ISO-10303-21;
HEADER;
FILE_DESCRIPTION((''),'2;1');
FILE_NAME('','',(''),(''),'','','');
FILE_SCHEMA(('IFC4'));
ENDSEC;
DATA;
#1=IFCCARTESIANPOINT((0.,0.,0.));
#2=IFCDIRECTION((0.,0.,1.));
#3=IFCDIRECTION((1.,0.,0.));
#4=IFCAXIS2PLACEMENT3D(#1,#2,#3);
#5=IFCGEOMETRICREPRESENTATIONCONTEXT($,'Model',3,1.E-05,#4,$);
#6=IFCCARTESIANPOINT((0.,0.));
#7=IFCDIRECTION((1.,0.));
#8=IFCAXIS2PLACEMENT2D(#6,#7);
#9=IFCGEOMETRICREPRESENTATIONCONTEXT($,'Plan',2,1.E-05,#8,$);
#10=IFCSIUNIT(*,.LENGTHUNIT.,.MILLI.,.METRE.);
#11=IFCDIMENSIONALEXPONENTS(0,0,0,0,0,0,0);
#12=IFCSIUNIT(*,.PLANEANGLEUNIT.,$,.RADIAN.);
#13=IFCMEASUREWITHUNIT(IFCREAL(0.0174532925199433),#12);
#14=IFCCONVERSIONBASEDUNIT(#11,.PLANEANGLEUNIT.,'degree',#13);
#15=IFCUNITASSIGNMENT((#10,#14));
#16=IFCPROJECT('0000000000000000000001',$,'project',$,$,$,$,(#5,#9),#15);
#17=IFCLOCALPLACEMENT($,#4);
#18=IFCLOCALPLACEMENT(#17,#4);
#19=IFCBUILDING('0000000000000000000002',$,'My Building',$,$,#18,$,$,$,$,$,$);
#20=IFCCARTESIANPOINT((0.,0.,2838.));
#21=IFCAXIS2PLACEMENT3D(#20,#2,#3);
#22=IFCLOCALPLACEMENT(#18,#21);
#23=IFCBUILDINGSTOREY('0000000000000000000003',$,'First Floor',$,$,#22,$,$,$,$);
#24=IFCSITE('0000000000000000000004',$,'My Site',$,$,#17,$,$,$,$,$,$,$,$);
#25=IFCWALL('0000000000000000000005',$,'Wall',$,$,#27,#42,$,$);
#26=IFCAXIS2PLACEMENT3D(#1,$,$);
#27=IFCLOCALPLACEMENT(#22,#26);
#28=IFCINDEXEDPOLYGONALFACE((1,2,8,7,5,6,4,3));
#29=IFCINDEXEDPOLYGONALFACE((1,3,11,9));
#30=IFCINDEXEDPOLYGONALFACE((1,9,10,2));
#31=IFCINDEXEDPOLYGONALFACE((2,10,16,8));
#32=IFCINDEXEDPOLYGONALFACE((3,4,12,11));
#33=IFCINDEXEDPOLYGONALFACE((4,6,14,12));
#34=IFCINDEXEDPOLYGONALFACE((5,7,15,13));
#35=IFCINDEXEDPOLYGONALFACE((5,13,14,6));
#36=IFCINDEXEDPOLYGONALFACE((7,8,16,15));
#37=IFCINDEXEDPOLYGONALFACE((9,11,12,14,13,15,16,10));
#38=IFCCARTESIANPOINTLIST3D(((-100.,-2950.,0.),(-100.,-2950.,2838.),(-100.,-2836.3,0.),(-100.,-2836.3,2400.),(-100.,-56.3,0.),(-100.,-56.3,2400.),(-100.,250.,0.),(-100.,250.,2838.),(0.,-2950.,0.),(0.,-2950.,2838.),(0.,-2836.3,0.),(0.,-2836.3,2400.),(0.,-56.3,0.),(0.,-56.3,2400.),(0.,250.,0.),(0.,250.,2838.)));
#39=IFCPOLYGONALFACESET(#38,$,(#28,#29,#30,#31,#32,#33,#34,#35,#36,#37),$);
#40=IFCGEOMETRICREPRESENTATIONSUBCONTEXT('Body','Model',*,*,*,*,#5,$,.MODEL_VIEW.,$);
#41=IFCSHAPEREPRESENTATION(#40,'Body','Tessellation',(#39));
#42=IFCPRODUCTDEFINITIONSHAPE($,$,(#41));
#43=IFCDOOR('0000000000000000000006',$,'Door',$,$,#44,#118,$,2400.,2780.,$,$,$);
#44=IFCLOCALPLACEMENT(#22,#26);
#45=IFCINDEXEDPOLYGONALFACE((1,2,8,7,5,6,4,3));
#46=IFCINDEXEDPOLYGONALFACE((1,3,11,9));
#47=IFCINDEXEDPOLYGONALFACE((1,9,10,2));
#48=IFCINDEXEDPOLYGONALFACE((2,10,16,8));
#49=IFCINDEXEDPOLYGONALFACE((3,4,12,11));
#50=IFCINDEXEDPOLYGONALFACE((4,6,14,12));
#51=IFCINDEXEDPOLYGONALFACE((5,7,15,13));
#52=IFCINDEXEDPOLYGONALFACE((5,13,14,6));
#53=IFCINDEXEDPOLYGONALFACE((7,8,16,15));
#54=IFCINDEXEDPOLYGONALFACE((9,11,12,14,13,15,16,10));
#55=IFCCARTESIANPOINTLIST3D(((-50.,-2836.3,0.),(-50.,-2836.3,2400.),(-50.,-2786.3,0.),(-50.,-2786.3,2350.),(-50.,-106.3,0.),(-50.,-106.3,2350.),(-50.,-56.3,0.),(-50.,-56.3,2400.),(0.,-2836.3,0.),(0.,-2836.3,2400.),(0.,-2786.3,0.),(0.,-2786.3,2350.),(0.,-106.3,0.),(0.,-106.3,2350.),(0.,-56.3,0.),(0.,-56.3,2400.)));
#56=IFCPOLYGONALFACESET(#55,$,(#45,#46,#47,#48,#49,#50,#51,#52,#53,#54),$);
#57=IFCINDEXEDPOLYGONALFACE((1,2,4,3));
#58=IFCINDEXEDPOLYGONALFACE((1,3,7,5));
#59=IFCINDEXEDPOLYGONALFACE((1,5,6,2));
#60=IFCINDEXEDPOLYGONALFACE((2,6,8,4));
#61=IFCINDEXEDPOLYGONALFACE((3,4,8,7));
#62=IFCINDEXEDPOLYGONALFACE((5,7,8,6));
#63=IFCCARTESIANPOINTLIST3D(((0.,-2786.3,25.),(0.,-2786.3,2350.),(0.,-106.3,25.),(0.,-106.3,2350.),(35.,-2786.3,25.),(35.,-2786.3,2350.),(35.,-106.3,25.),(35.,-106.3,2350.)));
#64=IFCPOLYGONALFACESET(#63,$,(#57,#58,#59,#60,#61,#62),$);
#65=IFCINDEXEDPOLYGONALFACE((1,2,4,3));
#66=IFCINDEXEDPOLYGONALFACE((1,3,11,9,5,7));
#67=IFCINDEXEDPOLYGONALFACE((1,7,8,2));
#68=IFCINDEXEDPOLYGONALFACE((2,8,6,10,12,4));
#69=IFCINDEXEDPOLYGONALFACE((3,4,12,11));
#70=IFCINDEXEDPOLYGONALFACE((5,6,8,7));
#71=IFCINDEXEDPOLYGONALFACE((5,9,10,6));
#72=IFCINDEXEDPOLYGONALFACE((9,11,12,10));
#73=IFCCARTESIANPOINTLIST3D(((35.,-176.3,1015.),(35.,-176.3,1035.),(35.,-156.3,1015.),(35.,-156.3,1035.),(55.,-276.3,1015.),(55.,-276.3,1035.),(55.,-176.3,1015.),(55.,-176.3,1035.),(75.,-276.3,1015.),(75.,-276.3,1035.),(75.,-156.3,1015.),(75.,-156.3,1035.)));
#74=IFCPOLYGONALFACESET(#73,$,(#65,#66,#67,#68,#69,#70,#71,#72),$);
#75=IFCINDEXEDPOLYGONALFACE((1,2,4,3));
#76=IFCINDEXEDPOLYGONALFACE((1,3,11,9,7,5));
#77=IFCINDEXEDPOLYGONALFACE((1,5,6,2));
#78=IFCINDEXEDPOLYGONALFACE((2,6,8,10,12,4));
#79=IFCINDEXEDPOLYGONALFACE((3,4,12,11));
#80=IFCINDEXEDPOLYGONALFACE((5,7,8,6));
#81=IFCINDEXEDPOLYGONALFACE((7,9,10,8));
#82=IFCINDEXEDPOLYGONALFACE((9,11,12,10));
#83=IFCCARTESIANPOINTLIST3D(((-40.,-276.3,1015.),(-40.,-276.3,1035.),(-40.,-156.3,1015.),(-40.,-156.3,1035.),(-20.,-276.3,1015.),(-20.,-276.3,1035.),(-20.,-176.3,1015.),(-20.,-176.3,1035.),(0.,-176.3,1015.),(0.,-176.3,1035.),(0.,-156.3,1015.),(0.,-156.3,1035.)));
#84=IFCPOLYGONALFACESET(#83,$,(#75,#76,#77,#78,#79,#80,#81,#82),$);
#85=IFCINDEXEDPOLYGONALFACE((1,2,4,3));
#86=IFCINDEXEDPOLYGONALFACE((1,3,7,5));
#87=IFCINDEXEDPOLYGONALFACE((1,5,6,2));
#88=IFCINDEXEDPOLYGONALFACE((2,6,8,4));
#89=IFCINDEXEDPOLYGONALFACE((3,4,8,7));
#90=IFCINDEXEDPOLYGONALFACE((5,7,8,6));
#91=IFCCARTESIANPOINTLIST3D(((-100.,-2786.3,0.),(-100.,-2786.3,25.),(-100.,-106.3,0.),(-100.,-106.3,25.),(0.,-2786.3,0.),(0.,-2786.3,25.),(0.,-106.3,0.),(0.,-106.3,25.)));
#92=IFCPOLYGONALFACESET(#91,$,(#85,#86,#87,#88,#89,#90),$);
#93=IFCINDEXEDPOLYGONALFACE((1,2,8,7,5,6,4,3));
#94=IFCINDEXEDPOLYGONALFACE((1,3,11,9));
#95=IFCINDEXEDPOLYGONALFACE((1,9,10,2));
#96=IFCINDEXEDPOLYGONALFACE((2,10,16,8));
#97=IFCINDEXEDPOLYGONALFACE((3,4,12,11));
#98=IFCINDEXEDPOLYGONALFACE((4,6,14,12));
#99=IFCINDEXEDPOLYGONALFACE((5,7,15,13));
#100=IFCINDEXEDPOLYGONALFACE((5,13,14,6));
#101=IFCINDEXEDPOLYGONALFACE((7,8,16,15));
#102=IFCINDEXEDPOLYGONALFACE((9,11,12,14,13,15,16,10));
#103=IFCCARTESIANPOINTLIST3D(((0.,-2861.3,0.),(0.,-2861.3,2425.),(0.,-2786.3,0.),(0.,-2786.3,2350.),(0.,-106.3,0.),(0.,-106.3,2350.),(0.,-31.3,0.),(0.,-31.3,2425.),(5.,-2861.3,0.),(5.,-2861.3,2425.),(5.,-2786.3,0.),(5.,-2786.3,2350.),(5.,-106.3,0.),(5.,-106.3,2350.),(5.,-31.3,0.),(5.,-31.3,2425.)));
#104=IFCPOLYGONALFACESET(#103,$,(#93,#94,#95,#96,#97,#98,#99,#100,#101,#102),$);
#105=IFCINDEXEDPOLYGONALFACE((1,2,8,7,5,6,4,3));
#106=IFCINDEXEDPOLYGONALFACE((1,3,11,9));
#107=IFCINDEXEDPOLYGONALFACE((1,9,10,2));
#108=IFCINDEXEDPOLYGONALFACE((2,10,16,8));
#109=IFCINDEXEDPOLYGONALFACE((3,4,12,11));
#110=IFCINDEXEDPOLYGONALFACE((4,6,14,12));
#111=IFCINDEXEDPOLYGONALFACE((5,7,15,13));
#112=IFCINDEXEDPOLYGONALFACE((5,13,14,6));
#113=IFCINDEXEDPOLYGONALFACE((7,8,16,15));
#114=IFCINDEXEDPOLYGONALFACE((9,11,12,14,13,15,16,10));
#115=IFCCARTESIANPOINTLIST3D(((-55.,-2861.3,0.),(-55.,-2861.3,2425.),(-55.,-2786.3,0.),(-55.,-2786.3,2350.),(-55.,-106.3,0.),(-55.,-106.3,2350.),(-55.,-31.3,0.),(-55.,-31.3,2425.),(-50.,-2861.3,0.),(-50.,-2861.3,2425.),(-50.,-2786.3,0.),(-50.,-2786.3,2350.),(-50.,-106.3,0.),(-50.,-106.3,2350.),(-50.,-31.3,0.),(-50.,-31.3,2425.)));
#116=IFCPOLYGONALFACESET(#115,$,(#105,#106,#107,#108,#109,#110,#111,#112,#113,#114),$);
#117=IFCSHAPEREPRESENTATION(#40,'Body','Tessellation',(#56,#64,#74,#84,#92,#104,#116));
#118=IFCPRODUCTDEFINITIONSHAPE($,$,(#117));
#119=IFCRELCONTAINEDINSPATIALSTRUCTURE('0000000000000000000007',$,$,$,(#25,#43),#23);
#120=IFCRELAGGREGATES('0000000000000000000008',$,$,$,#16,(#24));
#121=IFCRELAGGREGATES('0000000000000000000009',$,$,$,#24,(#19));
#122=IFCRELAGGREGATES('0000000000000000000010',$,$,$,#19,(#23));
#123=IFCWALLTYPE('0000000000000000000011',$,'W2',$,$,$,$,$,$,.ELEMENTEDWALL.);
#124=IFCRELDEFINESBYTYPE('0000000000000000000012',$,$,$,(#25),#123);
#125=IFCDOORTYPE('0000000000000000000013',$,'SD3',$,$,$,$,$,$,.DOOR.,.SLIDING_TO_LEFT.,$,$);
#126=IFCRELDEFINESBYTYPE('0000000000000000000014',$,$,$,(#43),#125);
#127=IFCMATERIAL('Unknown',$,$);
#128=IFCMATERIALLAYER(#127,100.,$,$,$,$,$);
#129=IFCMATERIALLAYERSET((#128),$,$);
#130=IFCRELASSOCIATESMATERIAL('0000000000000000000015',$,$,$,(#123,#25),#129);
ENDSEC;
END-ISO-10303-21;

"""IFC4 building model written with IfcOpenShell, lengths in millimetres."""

from ifc_helpers import new_model, entity, si_unit, converted_unit, frame, origin_with_axes, origin_2d_with_axis, place, context, subcontext, project, spatial, line, indexed_curve, outline, extrude, shape, source, transform, mapped, material, layer, layer_set, layer_usage, type_object, type_shapes, element, fill, save


model = new_model("IFC4")

# Units and contexts
model_context = context("Model", 3, precision=1e-05, world=origin_with_axes())
plan_context = context("Plan", 2, precision=1e-05, world=origin_2d_with_axis())
body_context_1 = subcontext(model_context, "Body", "Model", "MODEL_VIEW")
body_context_2 = subcontext(plan_context, "Body", "Plan", "PLAN_VIEW")
ifc_project = project(units=[si_unit("LENGTHUNIT", "METRE", prefix="MILLI"), converted_unit("PLANEANGLEUNIT", "degree", entity("IfcReal", 0.0174532925199433), si_unit("PLANEANGLEUNIT", "RADIAN"), dimensions=[0, 0, 0, 0, 0, 0, 0])], contexts=[model_context, plan_context])

# Site, building, storey
site_placement = place(None, origin_with_axes())
site = spatial("IfcSite", under=ifc_project, at=site_placement, Name="My Site")
building_placement = place(site_placement, origin_with_axes())
building = spatial("IfcBuilding", under=site, at=building_placement, Name="My Building")
storey_placement = place(building_placement, frame((0.0, 0.0, 2838.0), z_axis=(0.0, 0.0, 1.0), x_axis=(1.0, 0.0, 0.0)))
storey = spatial("IfcBuildingStorey", under=building, at=storey_placement, Name="First Floor")

# Shared definitions
ifc_material = material(Name="Unknown")

# Shared definitions
ifc_layer_1 = layer(ifc_material, 100.0)
ifc_layer_set_1 = layer_set([ifc_layer_1])
wall_type = type_object("IfcWallType", Name="W2", PredefinedType="ELEMENTEDWALL", material=ifc_layer_set_1)

# Wall, opening, door
ifc_layer_usage_1 = layer_usage(ifc_layer_set_1, "AXIS2", "POSITIVE", 0.0)
wall_1_placement = place(storey_placement, frame((0.0, -2950.0, 0.0), z_axis=(0.0, 0.0, 1.0), x_axis=(0.0, 1.0, 0.0)))
wall_1 = element("IfcWall", 1, at=wall_1_placement, inside=storey, type_object=wall_type, material=ifc_layer_usage_1, Name="Wall", context=body_context_1, shape_type="SweptSolid", body=[
    extrude(outline(indexed_curve([(0.0, 0.0), (0.0, 100.0), (3200.0, 100.0), (3200.0, 0.0), (0.0, 0.0)], self_intersect=False)), origin_with_axes(), (0.0, 0.0, 1.0), 2838.0),
])
shared_shape_1 = source(origin_with_axes(), body_context_1, "Body", "SolidModel", [
    extrude(outline(indexed_curve([(0.0, 0.0), (2780.0, 0.0), (2780.0, 2400.0), (0.0, 2400.0)], segments=[line(1, 2, 3, 4, 1)])), frame((0.0, -600.0, 0.0), z_axis=(0.0, -1.0, 0.0), x_axis=(1.0, 0.0, 0.0)), (0.0, 0.0, -1.0), 1200.0),
])
opening_1_placement = place(wall_1_placement, frame((113.7, 0.0, 0.0), z_axis=(0.0, 0.0, 1.0), x_axis=(1.0, 0.0, 0.0)))
opening_1 = element("IfcOpeningElement", 2, at=opening_1_placement, cuts=wall_1, PredefinedType="OPENING", context=body_context_1, shape_type="MappedRepresentation", body=[
    mapped(shared_shape_1, transform((0.0, 0.0, 0.0), x_axis=(1.0, 0.0, 0.0), y_axis=(0.0, 1.0, 0.0), z_axis=(0.0, 0.0, 1.0), scale=1.0)),
])
door_type_1 = type_object("IfcDoorType", Name="SD3", OperationType="SLIDING_TO_LEFT", PredefinedType="DOOR")
shared_shape_2 = source(origin_with_axes(), body_context_1, "Body", "SolidModel", [
    extrude(outline(indexed_curve([(0.0, 0.0), (0.0, 2400.0), (2780.0, 2400.0), (2780.0, 0.0), (2730.0, 0.0), (2730.0, 2350.0), (50.0, 2350.0), (50.0, 0.0)], segments=[line(1, 2, 3, 4, 5, 6, 7, 8, 1)])), frame((0.0, 0.0, 0.0), z_axis=(0.0, -1.0, 0.0), x_axis=(1.0, 0.0, 0.0)), (0.0, 0.0, -1.0), 50.0),
    extrude(outline(indexed_curve([(0.0, 0.0), (2680.0, 0.0), (2680.0, 35.0), (0.0, 35.0)], segments=[line(1, 2, 3, 4, 1)])), frame((50.0, -35.0, 25.0), z_axis=(0.0, 0.0, 1.0), x_axis=(1.0, 0.0, 0.0)), (0.0, 0.0, 1.0), 2325.0),
    extrude(outline(indexed_curve([(0.0, 0.0), (0.0, -40.0), (-120.0, -40.0), (-120.0, -20.0), (-20.0, -20.0), (-20.0, 0.0)], segments=[line(1, 2, 3, 4, 5, 6, 1)])), frame((2680.0, -35.0, 1015.0), z_axis=(0.0, 0.0, 1.0), x_axis=(1.0, 0.0, 0.0)), (0.0, 0.0, 1.0), 20.0),
    extrude(outline(indexed_curve([(0.0, 0.0), (0.0, 40.0), (-120.0, 40.0), (-120.0, 20.0), (-20.0, 20.0), (-20.0, 0.0)], segments=[line(1, 2, 3, 4, 5, 6, 1)])), frame((2680.0, 0.0, 1015.0), z_axis=(0.0, 0.0, 1.0), x_axis=(1.0, 0.0, 0.0)), (0.0, 0.0, 1.0), 20.0),
    extrude(outline(indexed_curve([(0.0, 0.0), (2680.0, 0.0), (2680.0, 100.0), (0.0, 100.0)], segments=[line(1, 2, 3, 4, 1)])), frame((50.0, 0.0, 0.0), z_axis=(0.0, 0.0, 1.0), x_axis=(1.0, 0.0, 0.0)), (0.0, 0.0, 1.0), 25.0),
    extrude(outline(indexed_curve([(0.0, 0.0), (0.0, 2425.0), (2830.0, 2425.0), (2830.0, 0.0), (2755.0, 0.0), (2755.0, 2350.0), (75.0, 2350.0), (75.0, 0.0)], segments=[line(1, 2, 3, 4, 5, 6, 7, 8, 1)])), frame((-25.0, -5.0, 0.0), z_axis=(0.0, -1.0, 0.0), x_axis=(1.0, 0.0, 0.0)), (0.0, 0.0, -1.0), 5.0),
    extrude(outline(indexed_curve([(0.0, 0.0), (0.0, 2425.0), (2830.0, 2425.0), (2830.0, 0.0), (2755.0, 0.0), (2755.0, 2350.0), (75.0, 2350.0), (75.0, 0.0)], segments=[line(1, 2, 3, 4, 5, 6, 7, 8, 1)])), frame((-25.0, 50.0, 0.0), z_axis=(0.0, -1.0, 0.0), x_axis=(1.0, 0.0, 0.0)), (0.0, 0.0, -1.0), 5.0),
])
shared_shape_3 = source(origin_with_axes(), body_context_2, "Body", "Curve2D", [
    entity("IfcIndexedPolyCurve", entity("IfcCartesianPointList2D", [[0.0, 0.0], [50.0, 0.0], [50.0, 50.0], [0.0, 50.0]]), [entity("IfcLineIndex", [1, 2, 3, 4, 1])]),
    entity("IfcIndexedPolyCurve", entity("IfcCartesianPointList2D", [[2780.0, 0.0], [2730.0, 0.0], [2730.0, 50.0], [2780.0, 50.0]]), [entity("IfcLineIndex", [1, 2, 3, 4, 1])]),
    entity("IfcIndexedPolyCurve", entity("IfcCartesianPointList2D", [[-1290.0, -35.0], [1390.0, -35.0], [1390.0, 0.0], [-1290.0, 0.0]]), [entity("IfcLineIndex", [1, 2, 3, 4, 1])]),
])
type_shapes(door_type_1, [shared_shape_2, shared_shape_3])
door_1_placement = place(opening_1_placement, origin_with_axes())
door_1 = element("IfcDoor", 3, at=door_1_placement, inside=storey, type_object=door_type_1, Name="Door", OverallHeight=2400.0, OverallWidth=2780.0, shapes=[
    shape(body_context_1, "Body", "MappedRepresentation", [mapped(shared_shape_2, transform((0.0, 0.0, 0.0), x_axis=(1.0, 0.0, 0.0), y_axis=(0.0, 1.0, 0.0), z_axis=(0.0, 0.0, 1.0), scale=1.0))]),
    shape(body_context_2, "Body", "MappedRepresentation", [mapped(shared_shape_3, transform((0.0, 0.0, 0.0), x_axis=(1.0, 0.0, 0.0), y_axis=(0.0, 1.0, 0.0), z_axis=(0.0, 0.0, 1.0), scale=1.0))]),
])
fill(opening_1, door_1)

save(model, "model.ifc")
